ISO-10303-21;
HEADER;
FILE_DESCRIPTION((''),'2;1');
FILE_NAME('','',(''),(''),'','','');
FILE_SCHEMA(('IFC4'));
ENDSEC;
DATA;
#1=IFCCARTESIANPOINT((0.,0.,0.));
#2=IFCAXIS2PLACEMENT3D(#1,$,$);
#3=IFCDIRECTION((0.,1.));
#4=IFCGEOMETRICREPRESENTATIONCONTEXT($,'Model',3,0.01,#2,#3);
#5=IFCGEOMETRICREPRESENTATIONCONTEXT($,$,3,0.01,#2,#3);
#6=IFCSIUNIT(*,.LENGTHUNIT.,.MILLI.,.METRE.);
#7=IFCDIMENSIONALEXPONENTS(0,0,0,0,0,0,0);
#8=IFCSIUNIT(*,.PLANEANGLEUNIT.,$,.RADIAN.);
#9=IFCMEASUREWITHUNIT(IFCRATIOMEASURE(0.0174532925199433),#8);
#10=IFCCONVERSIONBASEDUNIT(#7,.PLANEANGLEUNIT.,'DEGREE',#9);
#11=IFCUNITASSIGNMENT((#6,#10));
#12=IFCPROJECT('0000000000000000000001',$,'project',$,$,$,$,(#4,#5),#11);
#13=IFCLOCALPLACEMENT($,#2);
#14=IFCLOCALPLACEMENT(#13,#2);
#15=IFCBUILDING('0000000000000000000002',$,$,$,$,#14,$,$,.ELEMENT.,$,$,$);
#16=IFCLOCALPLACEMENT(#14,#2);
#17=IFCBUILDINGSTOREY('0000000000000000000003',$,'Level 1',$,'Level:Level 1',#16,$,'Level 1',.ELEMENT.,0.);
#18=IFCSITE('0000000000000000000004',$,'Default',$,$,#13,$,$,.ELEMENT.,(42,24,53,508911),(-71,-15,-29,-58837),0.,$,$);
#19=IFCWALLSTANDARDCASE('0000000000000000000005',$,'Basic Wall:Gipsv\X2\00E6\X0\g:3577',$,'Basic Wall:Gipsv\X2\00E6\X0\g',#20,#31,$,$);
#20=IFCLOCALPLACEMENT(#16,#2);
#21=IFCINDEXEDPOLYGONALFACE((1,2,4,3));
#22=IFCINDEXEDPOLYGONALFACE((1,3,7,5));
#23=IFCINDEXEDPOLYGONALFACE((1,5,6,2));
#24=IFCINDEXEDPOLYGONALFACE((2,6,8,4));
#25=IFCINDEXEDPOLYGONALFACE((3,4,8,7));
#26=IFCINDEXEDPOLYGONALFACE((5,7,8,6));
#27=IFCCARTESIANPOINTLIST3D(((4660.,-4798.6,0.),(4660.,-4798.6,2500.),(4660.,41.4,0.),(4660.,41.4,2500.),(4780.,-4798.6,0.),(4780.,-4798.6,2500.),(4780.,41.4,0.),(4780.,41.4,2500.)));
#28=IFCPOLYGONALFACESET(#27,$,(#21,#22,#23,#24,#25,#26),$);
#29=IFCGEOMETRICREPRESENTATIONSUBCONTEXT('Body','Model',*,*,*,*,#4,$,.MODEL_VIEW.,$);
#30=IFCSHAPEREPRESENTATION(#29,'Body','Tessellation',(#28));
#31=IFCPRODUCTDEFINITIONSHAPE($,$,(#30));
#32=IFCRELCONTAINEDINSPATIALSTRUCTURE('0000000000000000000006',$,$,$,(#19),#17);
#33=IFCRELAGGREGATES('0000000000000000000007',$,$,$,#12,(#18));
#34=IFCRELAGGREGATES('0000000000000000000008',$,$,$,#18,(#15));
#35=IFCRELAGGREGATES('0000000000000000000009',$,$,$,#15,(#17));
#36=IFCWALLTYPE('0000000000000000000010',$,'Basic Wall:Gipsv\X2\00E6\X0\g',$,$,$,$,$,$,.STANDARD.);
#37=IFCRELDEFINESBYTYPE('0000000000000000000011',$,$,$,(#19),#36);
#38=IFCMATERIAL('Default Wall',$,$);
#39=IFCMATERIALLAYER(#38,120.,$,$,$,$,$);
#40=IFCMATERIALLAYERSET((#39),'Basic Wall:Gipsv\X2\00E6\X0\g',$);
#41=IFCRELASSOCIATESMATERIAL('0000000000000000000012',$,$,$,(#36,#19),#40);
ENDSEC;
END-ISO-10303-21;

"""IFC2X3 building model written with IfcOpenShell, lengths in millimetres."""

from ifc_helpers import new_model, entity, si_unit, converted_unit, direction, frame, frame_2d, origin, place, context, subcontext, project, spatial, rectangle, extrude, material, layer, layer_set, layer_usage, type_object, element, save


model = new_model("IFC2X3")

# Units and contexts
model_context = context("Model", 3, precision=0.01, world=origin(), true_north=direction((0.0, 1.0)))
context_of_model = context(None, 3, precision=0.01, world=origin(), true_north=direction((0.0, 1.0)))
body_context = subcontext(model_context, "Body", "Model", "MODEL_VIEW")
ifc_project = project(units=[si_unit("LENGTHUNIT", "METRE", prefix="MILLI"), converted_unit("PLANEANGLEUNIT", "DEGREE", entity("IfcRatioMeasure", 0.0174532925199433), si_unit("PLANEANGLEUNIT", "RADIAN"), dimensions=[0, 0, 0, 0, 0, 0, 0])], contexts=[model_context, context_of_model])

# Site, building, storey
site_placement = place(None, origin())
site = spatial("IfcSite", under=ifc_project, at=site_placement, Name="Default", CompositionType="ELEMENT", RefLatitude=(42, 24, 53, 508911), RefLongitude=(-71, -15, -29, -58837), RefElevation=0.0)
building_placement = place(site_placement, origin())
building = spatial("IfcBuilding", under=site, at=building_placement, CompositionType="ELEMENT")
storey_placement = place(building_placement, origin())
storey = spatial("IfcBuildingStorey", under=building, at=storey_placement, Name="Level 1", ObjectType="Level:Level 1", LongName="Level 1", CompositionType="ELEMENT", Elevation=0.0)

# Shared definitions
ifc_material_1 = material(Name="Default Wall")

# Shared definitions
ifc_layer_1 = layer(ifc_material_1, 120.0)
ifc_layer_set_1 = layer_set([ifc_layer_1], Name="Basic Wall:Gipsvæg")
wall_type_1 = type_object("IfcWallType", Name="Basic Wall:Gipsvæg", PredefinedType="STANDARD", material=ifc_layer_set_1)

# Wall
ifc_layer_usage_1 = layer_usage(ifc_layer_set_1, "AXIS2", "NEGATIVE", 60.0)
wall_1_placement = place(storey_placement, frame((4720.0, 41.4, 0.0), z_axis=(0.0, 0.0, 1.0), x_axis=(0.0, -1.0, 0.0)))
element("IfcWallStandardCase", 1, at=wall_1_placement, inside=storey, type_object=wall_type_1, material=ifc_layer_usage_1, Name="Basic Wall:Gipsvæg:3577", ObjectType="Basic Wall:Gipsvæg", context=body_context, shape_type="SweptSolid", body=[
    extrude(rectangle(XDim=4840.0, YDim=120.0, at=frame_2d((2420.0, 0.0), x_axis=(-1.0, 0.0))), origin(), (0.0, 0.0, 1.0), 2500.0),
])

save(model, "model.ifc")
